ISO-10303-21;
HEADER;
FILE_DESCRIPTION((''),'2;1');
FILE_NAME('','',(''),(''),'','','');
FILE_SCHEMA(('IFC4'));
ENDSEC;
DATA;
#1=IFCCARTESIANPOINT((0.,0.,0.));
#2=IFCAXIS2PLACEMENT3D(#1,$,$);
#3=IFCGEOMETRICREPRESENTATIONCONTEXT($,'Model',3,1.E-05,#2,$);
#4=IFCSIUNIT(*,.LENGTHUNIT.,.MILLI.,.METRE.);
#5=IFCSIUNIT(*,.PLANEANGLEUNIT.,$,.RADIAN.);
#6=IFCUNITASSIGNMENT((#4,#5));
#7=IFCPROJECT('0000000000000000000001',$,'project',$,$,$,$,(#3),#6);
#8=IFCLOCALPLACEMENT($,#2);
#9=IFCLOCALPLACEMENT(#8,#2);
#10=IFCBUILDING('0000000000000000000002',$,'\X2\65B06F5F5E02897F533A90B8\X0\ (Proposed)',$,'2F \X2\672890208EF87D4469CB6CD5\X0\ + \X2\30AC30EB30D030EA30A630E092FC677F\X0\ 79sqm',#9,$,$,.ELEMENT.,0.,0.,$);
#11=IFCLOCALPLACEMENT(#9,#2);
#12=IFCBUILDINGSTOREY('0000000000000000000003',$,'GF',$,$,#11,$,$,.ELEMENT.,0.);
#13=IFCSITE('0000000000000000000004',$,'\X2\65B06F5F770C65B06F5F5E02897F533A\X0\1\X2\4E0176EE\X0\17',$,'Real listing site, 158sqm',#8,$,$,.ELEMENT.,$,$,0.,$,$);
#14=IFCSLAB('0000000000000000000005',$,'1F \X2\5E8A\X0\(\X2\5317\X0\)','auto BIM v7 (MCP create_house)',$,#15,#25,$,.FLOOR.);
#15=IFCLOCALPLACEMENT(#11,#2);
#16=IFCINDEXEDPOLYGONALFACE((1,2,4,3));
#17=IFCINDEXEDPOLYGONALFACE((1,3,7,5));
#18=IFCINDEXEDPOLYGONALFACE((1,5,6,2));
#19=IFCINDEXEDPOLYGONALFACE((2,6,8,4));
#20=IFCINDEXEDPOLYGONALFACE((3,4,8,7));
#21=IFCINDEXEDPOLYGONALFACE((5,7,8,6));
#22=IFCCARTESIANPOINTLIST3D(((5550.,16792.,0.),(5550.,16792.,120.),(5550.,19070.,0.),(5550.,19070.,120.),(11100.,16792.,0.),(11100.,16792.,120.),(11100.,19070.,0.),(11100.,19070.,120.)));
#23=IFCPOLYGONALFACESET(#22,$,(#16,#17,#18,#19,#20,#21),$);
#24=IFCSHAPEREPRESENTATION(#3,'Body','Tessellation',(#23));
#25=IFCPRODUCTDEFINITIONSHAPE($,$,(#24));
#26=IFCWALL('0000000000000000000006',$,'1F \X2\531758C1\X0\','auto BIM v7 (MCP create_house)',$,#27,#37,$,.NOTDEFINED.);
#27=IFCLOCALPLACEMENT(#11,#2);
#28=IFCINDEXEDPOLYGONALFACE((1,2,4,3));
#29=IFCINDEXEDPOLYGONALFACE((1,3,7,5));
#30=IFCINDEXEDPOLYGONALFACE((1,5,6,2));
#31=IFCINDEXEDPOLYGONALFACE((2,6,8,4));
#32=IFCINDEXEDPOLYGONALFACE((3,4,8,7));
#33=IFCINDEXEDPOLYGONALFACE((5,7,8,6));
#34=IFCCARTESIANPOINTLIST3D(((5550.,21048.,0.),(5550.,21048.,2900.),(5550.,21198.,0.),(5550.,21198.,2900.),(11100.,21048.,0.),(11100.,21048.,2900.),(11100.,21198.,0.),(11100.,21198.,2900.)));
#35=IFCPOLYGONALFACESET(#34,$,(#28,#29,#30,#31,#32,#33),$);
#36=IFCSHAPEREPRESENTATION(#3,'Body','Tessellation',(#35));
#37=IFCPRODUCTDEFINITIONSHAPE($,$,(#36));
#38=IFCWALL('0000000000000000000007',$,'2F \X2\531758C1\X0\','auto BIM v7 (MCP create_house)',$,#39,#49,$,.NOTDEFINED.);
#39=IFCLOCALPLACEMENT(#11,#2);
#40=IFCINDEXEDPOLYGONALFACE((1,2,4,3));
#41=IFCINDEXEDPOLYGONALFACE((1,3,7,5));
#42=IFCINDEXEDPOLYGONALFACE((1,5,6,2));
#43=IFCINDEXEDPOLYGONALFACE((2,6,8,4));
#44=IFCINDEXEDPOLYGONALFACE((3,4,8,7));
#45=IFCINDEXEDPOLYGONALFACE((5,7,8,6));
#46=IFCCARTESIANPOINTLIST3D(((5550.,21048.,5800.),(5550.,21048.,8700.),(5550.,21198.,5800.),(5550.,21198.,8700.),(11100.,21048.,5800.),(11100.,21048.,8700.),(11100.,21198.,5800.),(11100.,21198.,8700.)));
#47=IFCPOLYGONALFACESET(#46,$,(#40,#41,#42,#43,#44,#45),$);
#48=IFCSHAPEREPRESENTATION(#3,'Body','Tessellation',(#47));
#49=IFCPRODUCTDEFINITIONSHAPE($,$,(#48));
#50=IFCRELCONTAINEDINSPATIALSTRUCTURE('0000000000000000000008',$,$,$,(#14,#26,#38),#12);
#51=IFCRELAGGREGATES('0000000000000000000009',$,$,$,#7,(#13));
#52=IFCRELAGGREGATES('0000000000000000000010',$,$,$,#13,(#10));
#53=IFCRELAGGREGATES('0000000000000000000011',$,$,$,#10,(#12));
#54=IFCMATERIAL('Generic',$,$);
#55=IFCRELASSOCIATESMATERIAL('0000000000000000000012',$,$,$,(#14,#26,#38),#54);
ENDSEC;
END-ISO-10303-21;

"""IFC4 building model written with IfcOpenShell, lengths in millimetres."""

from ifc_helpers import new_model, si_unit, frame, frame_2d, origin, place, context, project, spatial, rectangle, extrude, material, element, save


model = new_model("IFC4")

# Units and contexts
model_context = context("Model", 3, precision=1e-05, world=origin())
ifc_project = project(units=[si_unit("LENGTHUNIT", "METRE", prefix="MILLI"), si_unit("PLANEANGLEUNIT", "RADIAN")], contexts=[model_context])

# Site, building, storey
site_placement = place(None, origin())
site = spatial("IfcSite", under=ifc_project, at=site_placement, Name="新潟県新潟市西区1丁目17", ObjectType="Real listing site, 158sqm", CompositionType="ELEMENT", RefElevation=0.0)
building_placement = place(site_placement, origin())
building = spatial("IfcBuilding", under=site, at=building_placement, Name="新潟市西区邸 (Proposed)", ObjectType="2F 木造軸組構法 + ガルバリウム鋼板 79sqm", CompositionType="ELEMENT", ElevationOfRefHeight=0.0, ElevationOfTerrain=0.0)
storey_placement = place(building_placement, origin())
storey = spatial("IfcBuildingStorey", under=building, at=storey_placement, Name="GF", CompositionType="ELEMENT", Elevation=0.0)

# Slab
ifc_material = material(Name="Generic")
slab_1_placement = place(storey_placement, frame((2775.0, 8396.0, 0.0)))
element("IfcSlab", 1, at=slab_1_placement, inside=storey, material=ifc_material, Name="1F 床(北)", Description="auto BIM v7 (MCP create_house)", PredefinedType="FLOOR", context=model_context, shape_type="SweptSolid", body=[
    extrude(rectangle(XDim=5550.0, YDim=2278.0, at=frame_2d((2775.0, 1139.0))), frame((2775.0, 8396.0, 0.0)), (0.0, 0.0, 1.0), 120.0),
])

# Wall
wall_1_placement = place(storey_placement, frame((2775.0, 10524.0, 0.0)))
element("IfcWall", 2, at=wall_1_placement, inside=storey, material=ifc_material, Name="1F 北壁", Description="auto BIM v7 (MCP create_house)", PredefinedType="NOTDEFINED", context=model_context, shape_type="SweptSolid", body=[
    extrude(rectangle(XDim=5550.0, YDim=150.0, at=frame_2d((2775.0, 75.0))), frame((2775.0, 10524.0, 0.0)), (0.0, 0.0, 1.0), 2900.0),
])

# Wall
wall_2_placement = place(storey_placement, frame((2775.0, 10524.0, 2900.0)))
element("IfcWall", 3, at=wall_2_placement, inside=storey, material=ifc_material, Name="2F 北壁", Description="auto BIM v7 (MCP create_house)", PredefinedType="NOTDEFINED", context=model_context, shape_type="SweptSolid", body=[
    extrude(rectangle(XDim=5550.0, YDim=150.0, at=frame_2d((2775.0, 75.0))), frame((2775.0, 10524.0, 2900.0)), (0.0, 0.0, 1.0), 2900.0),
])

save(model, "model.ifc")
